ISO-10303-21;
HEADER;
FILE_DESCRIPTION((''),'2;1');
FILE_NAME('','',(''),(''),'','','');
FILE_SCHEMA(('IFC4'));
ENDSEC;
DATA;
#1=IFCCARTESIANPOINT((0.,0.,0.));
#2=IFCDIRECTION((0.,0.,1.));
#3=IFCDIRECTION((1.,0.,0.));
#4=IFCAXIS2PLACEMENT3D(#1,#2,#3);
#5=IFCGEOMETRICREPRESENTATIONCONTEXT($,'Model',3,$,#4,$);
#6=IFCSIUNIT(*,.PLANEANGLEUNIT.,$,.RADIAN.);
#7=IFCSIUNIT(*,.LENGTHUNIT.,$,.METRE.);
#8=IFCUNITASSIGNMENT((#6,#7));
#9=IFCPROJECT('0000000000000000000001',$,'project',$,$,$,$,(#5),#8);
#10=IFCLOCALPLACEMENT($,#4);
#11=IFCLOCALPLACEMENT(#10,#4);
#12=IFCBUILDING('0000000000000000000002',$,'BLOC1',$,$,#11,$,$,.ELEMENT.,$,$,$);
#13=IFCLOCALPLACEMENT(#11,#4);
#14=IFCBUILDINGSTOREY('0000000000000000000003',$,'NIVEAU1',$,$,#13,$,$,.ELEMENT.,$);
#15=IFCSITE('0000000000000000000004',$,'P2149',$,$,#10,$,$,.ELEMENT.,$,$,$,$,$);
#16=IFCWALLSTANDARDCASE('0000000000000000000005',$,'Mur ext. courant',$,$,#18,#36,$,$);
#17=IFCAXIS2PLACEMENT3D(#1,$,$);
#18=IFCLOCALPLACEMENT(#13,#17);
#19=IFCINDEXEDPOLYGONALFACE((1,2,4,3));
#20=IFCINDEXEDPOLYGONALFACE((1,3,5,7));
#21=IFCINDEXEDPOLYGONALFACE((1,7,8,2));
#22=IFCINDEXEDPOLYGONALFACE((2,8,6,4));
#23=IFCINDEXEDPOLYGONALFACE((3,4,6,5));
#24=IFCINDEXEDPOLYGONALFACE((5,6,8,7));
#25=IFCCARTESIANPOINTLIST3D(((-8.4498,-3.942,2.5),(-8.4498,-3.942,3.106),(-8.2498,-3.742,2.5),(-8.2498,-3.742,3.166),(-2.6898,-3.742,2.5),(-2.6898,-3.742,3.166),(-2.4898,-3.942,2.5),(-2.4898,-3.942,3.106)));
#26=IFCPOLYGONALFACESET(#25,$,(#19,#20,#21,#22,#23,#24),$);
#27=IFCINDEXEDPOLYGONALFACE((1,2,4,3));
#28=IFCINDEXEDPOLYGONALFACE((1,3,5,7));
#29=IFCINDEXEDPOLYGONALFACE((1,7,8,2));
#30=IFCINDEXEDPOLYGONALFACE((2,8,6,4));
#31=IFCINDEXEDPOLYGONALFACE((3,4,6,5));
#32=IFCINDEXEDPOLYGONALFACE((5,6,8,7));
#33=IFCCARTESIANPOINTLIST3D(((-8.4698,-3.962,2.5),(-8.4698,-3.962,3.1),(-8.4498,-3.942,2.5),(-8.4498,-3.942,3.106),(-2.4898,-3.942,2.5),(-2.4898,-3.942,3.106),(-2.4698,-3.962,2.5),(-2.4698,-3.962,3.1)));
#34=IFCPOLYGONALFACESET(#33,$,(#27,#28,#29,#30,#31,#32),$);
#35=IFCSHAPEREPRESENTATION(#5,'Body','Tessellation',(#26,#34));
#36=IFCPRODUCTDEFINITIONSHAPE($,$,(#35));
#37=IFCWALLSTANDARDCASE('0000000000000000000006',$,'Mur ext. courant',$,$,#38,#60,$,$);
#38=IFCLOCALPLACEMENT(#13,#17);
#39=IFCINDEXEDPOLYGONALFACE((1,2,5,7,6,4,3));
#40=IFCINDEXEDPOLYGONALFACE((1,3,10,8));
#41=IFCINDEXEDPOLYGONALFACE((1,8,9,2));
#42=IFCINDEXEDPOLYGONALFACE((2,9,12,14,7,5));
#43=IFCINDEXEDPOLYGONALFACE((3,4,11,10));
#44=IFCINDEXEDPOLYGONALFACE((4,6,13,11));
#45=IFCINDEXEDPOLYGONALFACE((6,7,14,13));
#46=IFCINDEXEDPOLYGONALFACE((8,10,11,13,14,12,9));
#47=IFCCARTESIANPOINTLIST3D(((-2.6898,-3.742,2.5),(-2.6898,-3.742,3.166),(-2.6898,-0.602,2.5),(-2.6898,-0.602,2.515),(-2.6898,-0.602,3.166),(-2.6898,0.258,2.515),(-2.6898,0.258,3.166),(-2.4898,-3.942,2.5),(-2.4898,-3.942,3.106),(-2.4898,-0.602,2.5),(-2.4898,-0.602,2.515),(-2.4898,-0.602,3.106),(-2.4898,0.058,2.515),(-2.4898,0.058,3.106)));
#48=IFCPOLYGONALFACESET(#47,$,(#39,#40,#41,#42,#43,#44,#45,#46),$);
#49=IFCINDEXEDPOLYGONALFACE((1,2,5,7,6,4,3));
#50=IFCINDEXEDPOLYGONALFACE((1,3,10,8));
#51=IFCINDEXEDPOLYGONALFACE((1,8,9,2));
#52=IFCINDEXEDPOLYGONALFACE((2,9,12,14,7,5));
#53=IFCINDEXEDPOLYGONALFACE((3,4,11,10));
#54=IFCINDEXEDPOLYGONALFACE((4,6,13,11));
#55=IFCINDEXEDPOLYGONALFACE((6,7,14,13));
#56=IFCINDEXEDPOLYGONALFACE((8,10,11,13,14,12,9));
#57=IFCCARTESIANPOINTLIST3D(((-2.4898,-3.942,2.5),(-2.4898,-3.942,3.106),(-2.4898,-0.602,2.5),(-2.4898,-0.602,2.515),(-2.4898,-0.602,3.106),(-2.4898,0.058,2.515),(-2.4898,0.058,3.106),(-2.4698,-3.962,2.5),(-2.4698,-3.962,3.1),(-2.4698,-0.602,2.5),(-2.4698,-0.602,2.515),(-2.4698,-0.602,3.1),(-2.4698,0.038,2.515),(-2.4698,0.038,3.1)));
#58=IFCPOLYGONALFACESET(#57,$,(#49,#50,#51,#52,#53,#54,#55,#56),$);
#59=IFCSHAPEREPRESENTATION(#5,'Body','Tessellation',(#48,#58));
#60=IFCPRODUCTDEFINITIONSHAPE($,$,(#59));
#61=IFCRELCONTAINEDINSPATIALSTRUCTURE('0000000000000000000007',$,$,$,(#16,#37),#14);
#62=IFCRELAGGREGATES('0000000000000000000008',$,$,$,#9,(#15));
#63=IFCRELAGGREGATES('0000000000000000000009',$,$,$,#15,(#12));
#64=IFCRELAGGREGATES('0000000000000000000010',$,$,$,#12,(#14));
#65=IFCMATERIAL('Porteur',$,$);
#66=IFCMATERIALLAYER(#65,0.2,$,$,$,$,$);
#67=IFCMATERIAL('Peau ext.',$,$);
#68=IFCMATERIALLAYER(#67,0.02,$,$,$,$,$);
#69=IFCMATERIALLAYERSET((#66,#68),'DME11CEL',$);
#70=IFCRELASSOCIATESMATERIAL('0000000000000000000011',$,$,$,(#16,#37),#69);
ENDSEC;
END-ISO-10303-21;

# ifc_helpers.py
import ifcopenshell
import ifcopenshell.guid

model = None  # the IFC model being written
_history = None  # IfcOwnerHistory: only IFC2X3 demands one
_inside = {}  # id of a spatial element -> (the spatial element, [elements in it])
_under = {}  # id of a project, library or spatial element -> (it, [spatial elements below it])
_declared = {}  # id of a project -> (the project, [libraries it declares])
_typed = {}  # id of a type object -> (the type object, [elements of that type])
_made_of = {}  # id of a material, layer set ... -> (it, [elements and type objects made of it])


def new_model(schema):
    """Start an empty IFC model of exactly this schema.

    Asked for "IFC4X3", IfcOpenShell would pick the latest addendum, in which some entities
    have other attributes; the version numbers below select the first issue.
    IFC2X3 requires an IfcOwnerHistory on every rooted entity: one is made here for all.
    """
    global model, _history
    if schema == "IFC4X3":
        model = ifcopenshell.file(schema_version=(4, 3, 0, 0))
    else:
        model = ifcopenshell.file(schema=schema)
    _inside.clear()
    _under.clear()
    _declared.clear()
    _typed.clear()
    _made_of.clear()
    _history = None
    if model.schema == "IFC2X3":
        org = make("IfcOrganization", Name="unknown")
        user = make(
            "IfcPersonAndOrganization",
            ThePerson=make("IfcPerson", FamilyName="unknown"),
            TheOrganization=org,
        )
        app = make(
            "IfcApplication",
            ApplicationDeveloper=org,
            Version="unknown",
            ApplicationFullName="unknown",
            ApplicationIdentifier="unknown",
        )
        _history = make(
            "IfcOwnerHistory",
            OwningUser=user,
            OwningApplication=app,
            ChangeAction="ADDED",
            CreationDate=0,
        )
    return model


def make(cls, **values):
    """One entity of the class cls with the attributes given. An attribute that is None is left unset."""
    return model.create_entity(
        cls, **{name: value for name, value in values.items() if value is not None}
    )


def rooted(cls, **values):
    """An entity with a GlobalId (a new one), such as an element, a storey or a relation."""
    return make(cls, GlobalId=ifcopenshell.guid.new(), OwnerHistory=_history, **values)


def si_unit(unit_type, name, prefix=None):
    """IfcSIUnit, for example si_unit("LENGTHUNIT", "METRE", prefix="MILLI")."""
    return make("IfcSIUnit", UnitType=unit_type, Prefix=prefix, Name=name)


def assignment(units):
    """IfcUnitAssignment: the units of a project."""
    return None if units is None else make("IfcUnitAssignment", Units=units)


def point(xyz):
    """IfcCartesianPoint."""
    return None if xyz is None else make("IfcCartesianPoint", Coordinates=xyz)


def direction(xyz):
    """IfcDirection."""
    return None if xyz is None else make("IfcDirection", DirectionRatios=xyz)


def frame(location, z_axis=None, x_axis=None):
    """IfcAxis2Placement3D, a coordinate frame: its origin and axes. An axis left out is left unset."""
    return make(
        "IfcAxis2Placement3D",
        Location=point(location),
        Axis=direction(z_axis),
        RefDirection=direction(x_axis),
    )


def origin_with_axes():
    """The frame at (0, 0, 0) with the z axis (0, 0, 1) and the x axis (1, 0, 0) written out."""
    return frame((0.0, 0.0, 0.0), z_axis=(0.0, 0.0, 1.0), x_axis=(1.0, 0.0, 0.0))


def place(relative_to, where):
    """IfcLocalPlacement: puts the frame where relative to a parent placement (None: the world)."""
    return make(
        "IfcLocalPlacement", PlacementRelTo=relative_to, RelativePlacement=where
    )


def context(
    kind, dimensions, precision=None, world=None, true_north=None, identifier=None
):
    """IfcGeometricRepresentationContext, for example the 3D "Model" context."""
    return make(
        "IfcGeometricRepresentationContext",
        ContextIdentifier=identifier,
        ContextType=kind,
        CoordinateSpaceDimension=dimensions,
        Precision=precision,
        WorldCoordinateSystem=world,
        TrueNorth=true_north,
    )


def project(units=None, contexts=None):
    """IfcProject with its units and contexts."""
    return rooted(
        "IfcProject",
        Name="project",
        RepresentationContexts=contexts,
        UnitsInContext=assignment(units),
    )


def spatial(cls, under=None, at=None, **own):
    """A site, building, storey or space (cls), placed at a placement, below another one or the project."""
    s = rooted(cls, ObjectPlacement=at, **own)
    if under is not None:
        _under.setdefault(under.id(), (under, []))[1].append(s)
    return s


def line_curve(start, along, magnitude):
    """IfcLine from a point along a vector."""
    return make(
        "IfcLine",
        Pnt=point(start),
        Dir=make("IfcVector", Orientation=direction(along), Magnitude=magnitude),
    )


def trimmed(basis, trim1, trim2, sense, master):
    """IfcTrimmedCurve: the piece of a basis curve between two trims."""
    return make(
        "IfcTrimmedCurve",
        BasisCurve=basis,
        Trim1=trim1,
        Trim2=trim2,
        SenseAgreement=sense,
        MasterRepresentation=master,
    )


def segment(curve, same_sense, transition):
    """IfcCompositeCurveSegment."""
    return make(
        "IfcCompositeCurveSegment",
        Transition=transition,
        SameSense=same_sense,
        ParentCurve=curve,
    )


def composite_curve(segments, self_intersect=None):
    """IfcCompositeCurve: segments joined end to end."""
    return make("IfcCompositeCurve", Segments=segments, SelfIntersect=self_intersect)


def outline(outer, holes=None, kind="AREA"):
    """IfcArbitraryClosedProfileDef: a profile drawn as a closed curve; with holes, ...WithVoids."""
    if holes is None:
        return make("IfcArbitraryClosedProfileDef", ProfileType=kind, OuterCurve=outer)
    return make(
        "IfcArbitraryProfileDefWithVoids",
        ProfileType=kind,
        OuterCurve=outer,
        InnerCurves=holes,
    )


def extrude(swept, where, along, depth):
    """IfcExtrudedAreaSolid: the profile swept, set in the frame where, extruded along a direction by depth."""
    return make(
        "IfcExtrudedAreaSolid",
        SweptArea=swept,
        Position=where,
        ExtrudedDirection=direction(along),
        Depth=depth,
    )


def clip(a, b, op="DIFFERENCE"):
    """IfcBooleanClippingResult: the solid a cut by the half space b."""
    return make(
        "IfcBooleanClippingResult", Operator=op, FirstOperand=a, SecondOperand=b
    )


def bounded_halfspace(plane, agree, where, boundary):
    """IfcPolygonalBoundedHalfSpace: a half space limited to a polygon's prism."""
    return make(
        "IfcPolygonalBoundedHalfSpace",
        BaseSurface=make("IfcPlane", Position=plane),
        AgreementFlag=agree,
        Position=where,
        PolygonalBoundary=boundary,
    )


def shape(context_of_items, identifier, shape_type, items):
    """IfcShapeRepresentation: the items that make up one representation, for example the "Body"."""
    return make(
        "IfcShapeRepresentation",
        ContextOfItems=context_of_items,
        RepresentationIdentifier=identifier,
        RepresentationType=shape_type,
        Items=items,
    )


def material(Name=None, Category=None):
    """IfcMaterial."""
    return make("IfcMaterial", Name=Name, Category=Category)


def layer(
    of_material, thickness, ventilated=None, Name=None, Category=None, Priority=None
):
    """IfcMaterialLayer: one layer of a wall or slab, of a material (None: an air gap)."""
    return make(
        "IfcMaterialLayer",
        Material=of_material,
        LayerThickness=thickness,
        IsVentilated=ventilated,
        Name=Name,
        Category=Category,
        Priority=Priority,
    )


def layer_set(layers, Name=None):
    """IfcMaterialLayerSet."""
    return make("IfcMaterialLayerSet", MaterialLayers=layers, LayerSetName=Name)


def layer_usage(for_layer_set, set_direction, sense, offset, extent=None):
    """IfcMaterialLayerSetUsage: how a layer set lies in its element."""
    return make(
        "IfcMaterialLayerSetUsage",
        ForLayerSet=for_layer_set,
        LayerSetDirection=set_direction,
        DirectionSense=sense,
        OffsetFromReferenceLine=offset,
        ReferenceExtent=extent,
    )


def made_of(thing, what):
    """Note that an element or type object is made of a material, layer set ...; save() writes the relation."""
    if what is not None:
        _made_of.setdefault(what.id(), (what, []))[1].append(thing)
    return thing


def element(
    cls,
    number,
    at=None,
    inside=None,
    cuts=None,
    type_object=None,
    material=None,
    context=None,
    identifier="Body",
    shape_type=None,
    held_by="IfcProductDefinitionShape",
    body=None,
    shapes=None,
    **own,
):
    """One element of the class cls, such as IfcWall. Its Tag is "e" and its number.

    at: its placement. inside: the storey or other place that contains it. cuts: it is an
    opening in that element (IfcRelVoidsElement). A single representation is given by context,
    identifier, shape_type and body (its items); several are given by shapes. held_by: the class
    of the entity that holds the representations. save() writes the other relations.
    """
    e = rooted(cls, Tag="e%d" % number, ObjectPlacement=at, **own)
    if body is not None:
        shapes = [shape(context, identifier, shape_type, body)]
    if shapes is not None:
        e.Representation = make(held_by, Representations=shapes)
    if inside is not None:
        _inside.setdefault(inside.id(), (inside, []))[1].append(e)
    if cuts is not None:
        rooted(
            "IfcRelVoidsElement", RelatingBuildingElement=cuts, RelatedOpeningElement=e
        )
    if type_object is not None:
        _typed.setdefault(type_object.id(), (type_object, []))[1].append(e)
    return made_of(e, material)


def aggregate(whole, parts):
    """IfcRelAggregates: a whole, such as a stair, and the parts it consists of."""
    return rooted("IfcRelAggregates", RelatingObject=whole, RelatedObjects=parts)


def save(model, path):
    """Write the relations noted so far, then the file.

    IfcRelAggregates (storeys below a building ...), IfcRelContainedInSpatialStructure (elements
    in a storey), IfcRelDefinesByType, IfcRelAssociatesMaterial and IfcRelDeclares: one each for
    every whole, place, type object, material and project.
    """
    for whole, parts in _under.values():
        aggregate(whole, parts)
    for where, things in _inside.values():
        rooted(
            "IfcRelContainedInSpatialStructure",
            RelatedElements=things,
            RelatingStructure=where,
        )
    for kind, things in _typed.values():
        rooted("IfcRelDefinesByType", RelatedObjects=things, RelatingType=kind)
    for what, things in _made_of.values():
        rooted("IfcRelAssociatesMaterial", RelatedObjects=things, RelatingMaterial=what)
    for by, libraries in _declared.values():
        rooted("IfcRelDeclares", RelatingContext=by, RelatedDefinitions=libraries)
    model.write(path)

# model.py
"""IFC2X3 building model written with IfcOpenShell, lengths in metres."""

from ifc_helpers import new_model, si_unit, point, frame, origin_with_axes, place, context, project, spatial, line_curve, trimmed, segment, composite_curve, outline, extrude, clip, bounded_halfspace, material, layer, layer_set, layer_usage, element, save


model = new_model("IFC2X3")

# Units and contexts
model_context = context("Model", 3, world=origin_with_axes())
ifc_project = project(units=[si_unit("PLANEANGLEUNIT", "RADIAN"), si_unit("LENGTHUNIT", "METRE")], contexts=[model_context])

# Site, building, storey
site_placement = place(None, origin_with_axes())
site = spatial("IfcSite", under=ifc_project, at=site_placement, Name="P2149", CompositionType="ELEMENT")
building_placement = place(site_placement, origin_with_axes())
building = spatial("IfcBuilding", under=site, at=building_placement, Name="BLOC1", CompositionType="ELEMENT")
storey_placement = place(building_placement, origin_with_axes())
storey = spatial("IfcBuildingStorey", under=building, at=storey_placement, Name="NIVEAU1", CompositionType="ELEMENT")

# Walls
ifc_material_1 = material(Name="Porteur")
ifc_layer_1 = layer(ifc_material_1, 0.2)
ifc_material_2 = material(Name="Peau ext.")
ifc_layer_2 = layer(ifc_material_2, 0.02)
ifc_layer_set = layer_set([ifc_layer_1, ifc_layer_2], Name="DME11CEL")
ifc_layer_usage = layer_usage(ifc_layer_set, "AXIS2", "POSITIVE", 0.0)
wall_1_placement = place(storey_placement, frame((-2.6898, -3.742, 2.5), z_axis=(0.0, 0.0, 1.0), x_axis=(-1.0, 0.0, 0.0)))
element("IfcWallStandardCase", 1, at=wall_1_placement, inside=storey, material=ifc_layer_usage, Name="Mur ext. courant", context=model_context, shape_type="Clipping", body=[
    clip(extrude(outline(composite_curve([segment(trimmed(line_curve((0.0, 0.0), (1.0, 0.0), 5.56), [point((0.0, 0.0))], [point((5.56, 0.0))], True, "CARTESIAN"), True, "CONTINUOUS"), segment(trimmed(line_curve((5.56, 0.0), (0.707107, 0.707107), 0.282843), [point((5.56, 0.0))], [point((5.76, 0.2))], True, "CARTESIAN"), True, "CONTINUOUS"), segment(trimmed(line_curve((5.76, 0.2), (-1.0, 0.0), 5.96), [point((5.76, 0.2))], [point((-0.2, 0.2))], True, "CARTESIAN"), True, "CONTINUOUS"), segment(trimmed(line_curve((-0.2, 0.2), (0.707107, -0.707107), 0.282843), [point((-0.2, 0.2))], [point((0.0, 0.0))], True, "CARTESIAN"), True, "CONTINUOUS")], self_intersect=False)), origin_with_axes(), (0.0, 0.0, 1.0), 0.666), bounded_halfspace(frame((0.0, 0.0, 0.666), z_axis=(0.0, 0.287348, 0.957826), x_axis=(0.0, 0.957826, -0.287348)), False, frame((0.0, 0.0, 0.666), z_axis=(0.0, 0.0, 1.0), x_axis=(1.0, 0.0, 0.0)), composite_curve([segment(trimmed(line_curve((0.0, 0.0), (1.0, 0.0), 5.56), [point((0.0, 0.0))], [point((5.56, 0.0))], True, "CARTESIAN"), True, "CONTINUOUS"), segment(trimmed(line_curve((5.56, 0.0), (0.707107, 0.707107), 0.282843), [point((5.56, 0.0))], [point((5.76, 0.2))], True, "CARTESIAN"), True, "CONTINUOUS"), segment(trimmed(line_curve((5.76, 0.2), (-1.0, 0.0), 5.96), [point((5.76, 0.2))], [point((-0.2, 0.2))], True, "CARTESIAN"), True, "CONTINUOUS"), segment(trimmed(line_curve((-0.2, 0.2), (0.707107, -0.707107), 0.282843), [point((-0.2, 0.2))], [point((0.0, 0.0))], True, "CARTESIAN"), True, "CONTINUOUS")], self_intersect=False))),
    clip(extrude(outline(composite_curve([segment(trimmed(line_curve((-0.2, 0.2), (1.0, 0.0), 5.96), [point((-0.2, 0.2))], [point((5.76, 0.2))], True, "CARTESIAN"), True, "CONTINUOUS"), segment(trimmed(line_curve((5.76, 0.2), (0.707107, 0.707107), 0.028284), [point((5.76, 0.2))], [point((5.78, 0.22))], True, "CARTESIAN"), True, "CONTINUOUS"), segment(trimmed(line_curve((5.78, 0.22), (-1.0, 0.0), 6.0), [point((5.78, 0.22))], [point((-0.22, 0.22))], True, "CARTESIAN"), True, "CONTINUOUS"), segment(trimmed(line_curve((-0.22, 0.22), (0.707107, -0.707107), 0.028284), [point((-0.22, 0.22))], [point((-0.2, 0.2))], True, "CARTESIAN"), True, "CONTINUOUS")], self_intersect=False)), origin_with_axes(), (0.0, 0.0, 1.0), 0.666), bounded_halfspace(frame((0.0, 0.0, 0.666), z_axis=(0.0, 0.287348, 0.957826), x_axis=(0.0, 0.957826, -0.287348)), False, frame((-0.2, 0.2, 0.606), z_axis=(0.0, 0.0, 1.0), x_axis=(1.0, 0.0, 0.0)), composite_curve([segment(trimmed(line_curve((0.0, 0.0), (1.0, 0.0), 5.96), [point((0.0, 0.0))], [point((5.96, 0.0))], True, "CARTESIAN"), True, "CONTINUOUS"), segment(trimmed(line_curve((5.96, 0.0), (0.707107, 0.707107), 0.028284), [point((5.96, 0.0))], [point((5.98, 0.02))], True, "CARTESIAN"), True, "CONTINUOUS"), segment(trimmed(line_curve((5.98, 0.02), (-1.0, 0.0), 6.0), [point((5.98, 0.02))], [point((-0.02, 0.02))], True, "CARTESIAN"), True, "CONTINUOUS"), segment(trimmed(line_curve((-0.02, 0.02), (0.707107, -0.707107), 0.028284), [point((-0.02, 0.02))], [point((0.0, 0.0))], True, "CARTESIAN"), True, "CONTINUOUS")], self_intersect=False))),
])
wall_2_placement = place(storey_placement, frame((-2.6898, 0.258, 2.5), z_axis=(0.0, 0.0, 1.0), x_axis=(0.0, -1.0, 0.0)))
element("IfcWallStandardCase", 2, at=wall_2_placement, inside=storey, material=ifc_layer_usage, Name="Mur ext. courant", context=model_context, shape_type="Clipping", body=[
    clip(clip(clip(extrude(outline(composite_curve([segment(trimmed(line_curve((0.0, 0.0), (1.0, 0.0), 4.0), [point((0.0, 0.0))], [point((4.0, 0.0))], True, "CARTESIAN"), True, "CONTINUOUS"), segment(trimmed(line_curve((4.0, 0.0), (0.707107, 0.707107), 0.282843), [point((4.0, 0.0))], [point((4.2, 0.2))], True, "CARTESIAN"), True, "CONTINUOUS"), segment(trimmed(line_curve((4.2, 0.2), (-1.0, 0.0), 4.0), [point((4.2, 0.2))], [point((0.2, 0.2))], True, "CARTESIAN"), True, "CONTINUOUS"), segment(trimmed(line_curve((0.2, 0.2), (-0.707107, -0.707107), 0.282843), [point((0.2, 0.2))], [point((0.0, 0.0))], True, "CARTESIAN"), True, "CONTINUOUS")], self_intersect=False)), origin_with_axes(), (0.0, 0.0, 1.0), 0.666), bounded_halfspace(frame((0.0, 0.0, 0.666), z_axis=(0.0, 0.287348, 0.957826), x_axis=(0.0, 0.957826, -0.287348)), False, frame((0.86, 0.0, 0.666), z_axis=(0.0, 0.0, 1.0), x_axis=(1.0, 0.0, 0.0)), composite_curve([segment(trimmed(line_curve((0.0, 0.0), (1.0, 0.0), 3.14), [point((0.0, 0.0))], [point((3.14, 0.0))], True, "CARTESIAN"), True, "CONTINUOUS"), segment(trimmed(line_curve((3.14, 0.0), (0.707107, 0.707107), 0.282843), [point((3.14, 0.0))], [point((3.34, 0.2))], True, "CARTESIAN"), True, "CONTINUOUS"), segment(trimmed(line_curve((3.34, 0.2), (-1.0, 0.0), 3.34), [point((3.34, 0.2))], [point((0.0, 0.2))], True, "CARTESIAN"), True, "CONTINUOUS"), segment(trimmed(line_curve((0.0, 0.2), (0.0, -1.0), 0.2), [point((0.0, 0.2))], [point((0.0, 0.0))], True, "CARTESIAN"), True, "CONTINUOUS")], self_intersect=False))), bounded_halfspace(frame((0.0, 0.0, 0.666), z_axis=(0.0, 0.287348, 0.957826), x_axis=(0.0, 0.957826, -0.287348)), False, frame((0.0, 0.0, 0.666), z_axis=(0.0, 0.0, 1.0), x_axis=(1.0, 0.0, 0.0)), composite_curve([segment(trimmed(line_curve((0.0, 0.0), (1.0, 0.0), 0.86), [point((0.0, 0.0))], [point((0.86, 0.0))], True, "CARTESIAN"), True, "CONTINUOUS"), segment(trimmed(line_curve((0.86, 0.0), (0.0, 1.0), 0.2), [point((0.86, 0.0))], [point((0.86, 0.2))], True, "CARTESIAN"), True, "CONTINUOUS"), segment(trimmed(line_curve((0.86, 0.2), (-1.0, 0.0), 0.66), [point((0.86, 0.2))], [point((0.2, 0.2))], True, "CARTESIAN"), True, "CONTINUOUS"), segment(trimmed(line_curve((0.2, 0.2), (-0.707107, -0.707107), 0.282843), [point((0.2, 0.2))], [point((0.0, 0.0))], True, "CARTESIAN"), True, "CONTINUOUS")], self_intersect=False))), bounded_halfspace(frame((0.0, 0.0, 0.015), z_axis=(0.0, 0.0, -1.0), x_axis=(0.0, 1.0, 0.0)), False, frame((0.0, 0.0, 0.015), z_axis=(0.0, 0.0, 1.0), x_axis=(1.0, 0.0, 0.0)), composite_curve([segment(trimmed(line_curve((0.0, 0.0), (1.0, 0.0), 0.86), [point((0.0, 0.0))], [point((0.86, 0.0))], True, "CARTESIAN"), True, "CONTINUOUS"), segment(trimmed(line_curve((0.86, 0.0), (0.0, 1.0), 0.2), [point((0.86, 0.0))], [point((0.86, 0.2))], True, "CARTESIAN"), True, "CONTINUOUS"), segment(trimmed(line_curve((0.86, 0.2), (-1.0, 0.0), 0.66), [point((0.86, 0.2))], [point((0.2, 0.2))], True, "CARTESIAN"), True, "CONTINUOUS"), segment(trimmed(line_curve((0.2, 0.2), (-0.707107, -0.707107), 0.282843), [point((0.2, 0.2))], [point((0.0, 0.0))], True, "CARTESIAN"), True, "CONTINUOUS")], self_intersect=False))),
    clip(clip(clip(extrude(outline(composite_curve([segment(trimmed(line_curve((0.2, 0.2), (1.0, 0.0), 4.0), [point((0.2, 0.2))], [point((4.2, 0.2))], True, "CARTESIAN"), True, "CONTINUOUS"), segment(trimmed(line_curve((4.2, 0.2), (0.707107, 0.707107), 0.028284), [point((4.2, 0.2))], [point((4.22, 0.22))], True, "CARTESIAN"), True, "CONTINUOUS"), segment(trimmed(line_curve((4.22, 0.22), (-1.0, 0.0), 4.0), [point((4.22, 0.22))], [point((0.22, 0.22))], True, "CARTESIAN"), True, "CONTINUOUS"), segment(trimmed(line_curve((0.22, 0.22), (-0.707107, -0.707107), 0.028284), [point((0.22, 0.22))], [point((0.2, 0.2))], True, "CARTESIAN"), True, "CONTINUOUS")], self_intersect=False)), origin_with_axes(), (0.0, 0.0, 1.0), 0.666), bounded_halfspace(frame((0.0, 0.0, 0.666), z_axis=(0.0, 0.287348, 0.957826), x_axis=(0.0, 0.957826, -0.287348)), False, frame((0.86, 0.2, 0.606), z_axis=(0.0, 0.0, 1.0), x_axis=(1.0, 0.0, 0.0)), composite_curve([segment(trimmed(line_curve((0.0, 0.0), (1.0, 0.0), 3.34), [point((0.0, 0.0))], [point((3.34, 0.0))], True, "CARTESIAN"), True, "CONTINUOUS"), segment(trimmed(line_curve((3.34, 0.0), (0.707107, 0.707107), 0.028284), [point((3.34, 0.0))], [point((3.36, 0.02))], True, "CARTESIAN"), True, "CONTINUOUS"), segment(trimmed(line_curve((3.36, 0.02), (-1.0, 0.0), 3.36), [point((3.36, 0.02))], [point((0.0, 0.02))], True, "CARTESIAN"), True, "CONTINUOUS"), segment(trimmed(line_curve((0.0, 0.02), (0.0, -1.0), 0.02), [point((0.0, 0.02))], [point((0.0, 0.0))], True, "CARTESIAN"), True, "CONTINUOUS")], self_intersect=False))), bounded_halfspace(frame((0.0, 0.0, 0.666), z_axis=(0.0, 0.287348, 0.957826), x_axis=(0.0, 0.957826, -0.287348)), False, frame((0.2, 0.2, 0.606), z_axis=(0.0, 0.0, 1.0), x_axis=(1.0, 0.0, 0.0)), composite_curve([segment(trimmed(line_curve((0.0, 0.0), (1.0, 0.0), 0.66), [point((0.0, 0.0))], [point((0.66, 0.0))], True, "CARTESIAN"), True, "CONTINUOUS"), segment(trimmed(line_curve((0.66, 0.0), (0.0, 1.0), 0.02), [point((0.66, 0.0))], [point((0.66, 0.02))], True, "CARTESIAN"), True, "CONTINUOUS"), segment(trimmed(line_curve((0.66, 0.02), (-1.0, 0.0), 0.64), [point((0.66, 0.02))], [point((0.02, 0.02))], True, "CARTESIAN"), True, "CONTINUOUS"), segment(trimmed(line_curve((0.02, 0.02), (-0.707107, -0.707107), 0.028284), [point((0.02, 0.02))], [point((0.0, 0.0))], True, "CARTESIAN"), True, "CONTINUOUS")], self_intersect=False))), bounded_halfspace(frame((0.0, 0.0, 0.015), z_axis=(0.0, 0.0, -1.0), x_axis=(0.0, 1.0, 0.0)), False, frame((0.2, 0.2, 0.015), z_axis=(0.0, 0.0, 1.0), x_axis=(1.0, 0.0, 0.0)), composite_curve([segment(trimmed(line_curve((0.0, 0.0), (1.0, 0.0), 0.66), [point((0.0, 0.0))], [point((0.66, 0.0))], True, "CARTESIAN"), True, "CONTINUOUS"), segment(trimmed(line_curve((0.66, 0.0), (0.0, 1.0), 0.02), [point((0.66, 0.0))], [point((0.66, 0.02))], True, "CARTESIAN"), True, "CONTINUOUS"), segment(trimmed(line_curve((0.66, 0.02), (-1.0, 0.0), 0.64), [point((0.66, 0.02))], [point((0.02, 0.02))], True, "CARTESIAN"), True, "CONTINUOUS"), segment(trimmed(line_curve((0.02, 0.02), (-0.707107, -0.707107), 0.028284), [point((0.02, 0.02))], [point((0.0, 0.0))], True, "CARTESIAN"), True, "CONTINUOUS")], self_intersect=False))),
])

save(model, "model.ifc")
